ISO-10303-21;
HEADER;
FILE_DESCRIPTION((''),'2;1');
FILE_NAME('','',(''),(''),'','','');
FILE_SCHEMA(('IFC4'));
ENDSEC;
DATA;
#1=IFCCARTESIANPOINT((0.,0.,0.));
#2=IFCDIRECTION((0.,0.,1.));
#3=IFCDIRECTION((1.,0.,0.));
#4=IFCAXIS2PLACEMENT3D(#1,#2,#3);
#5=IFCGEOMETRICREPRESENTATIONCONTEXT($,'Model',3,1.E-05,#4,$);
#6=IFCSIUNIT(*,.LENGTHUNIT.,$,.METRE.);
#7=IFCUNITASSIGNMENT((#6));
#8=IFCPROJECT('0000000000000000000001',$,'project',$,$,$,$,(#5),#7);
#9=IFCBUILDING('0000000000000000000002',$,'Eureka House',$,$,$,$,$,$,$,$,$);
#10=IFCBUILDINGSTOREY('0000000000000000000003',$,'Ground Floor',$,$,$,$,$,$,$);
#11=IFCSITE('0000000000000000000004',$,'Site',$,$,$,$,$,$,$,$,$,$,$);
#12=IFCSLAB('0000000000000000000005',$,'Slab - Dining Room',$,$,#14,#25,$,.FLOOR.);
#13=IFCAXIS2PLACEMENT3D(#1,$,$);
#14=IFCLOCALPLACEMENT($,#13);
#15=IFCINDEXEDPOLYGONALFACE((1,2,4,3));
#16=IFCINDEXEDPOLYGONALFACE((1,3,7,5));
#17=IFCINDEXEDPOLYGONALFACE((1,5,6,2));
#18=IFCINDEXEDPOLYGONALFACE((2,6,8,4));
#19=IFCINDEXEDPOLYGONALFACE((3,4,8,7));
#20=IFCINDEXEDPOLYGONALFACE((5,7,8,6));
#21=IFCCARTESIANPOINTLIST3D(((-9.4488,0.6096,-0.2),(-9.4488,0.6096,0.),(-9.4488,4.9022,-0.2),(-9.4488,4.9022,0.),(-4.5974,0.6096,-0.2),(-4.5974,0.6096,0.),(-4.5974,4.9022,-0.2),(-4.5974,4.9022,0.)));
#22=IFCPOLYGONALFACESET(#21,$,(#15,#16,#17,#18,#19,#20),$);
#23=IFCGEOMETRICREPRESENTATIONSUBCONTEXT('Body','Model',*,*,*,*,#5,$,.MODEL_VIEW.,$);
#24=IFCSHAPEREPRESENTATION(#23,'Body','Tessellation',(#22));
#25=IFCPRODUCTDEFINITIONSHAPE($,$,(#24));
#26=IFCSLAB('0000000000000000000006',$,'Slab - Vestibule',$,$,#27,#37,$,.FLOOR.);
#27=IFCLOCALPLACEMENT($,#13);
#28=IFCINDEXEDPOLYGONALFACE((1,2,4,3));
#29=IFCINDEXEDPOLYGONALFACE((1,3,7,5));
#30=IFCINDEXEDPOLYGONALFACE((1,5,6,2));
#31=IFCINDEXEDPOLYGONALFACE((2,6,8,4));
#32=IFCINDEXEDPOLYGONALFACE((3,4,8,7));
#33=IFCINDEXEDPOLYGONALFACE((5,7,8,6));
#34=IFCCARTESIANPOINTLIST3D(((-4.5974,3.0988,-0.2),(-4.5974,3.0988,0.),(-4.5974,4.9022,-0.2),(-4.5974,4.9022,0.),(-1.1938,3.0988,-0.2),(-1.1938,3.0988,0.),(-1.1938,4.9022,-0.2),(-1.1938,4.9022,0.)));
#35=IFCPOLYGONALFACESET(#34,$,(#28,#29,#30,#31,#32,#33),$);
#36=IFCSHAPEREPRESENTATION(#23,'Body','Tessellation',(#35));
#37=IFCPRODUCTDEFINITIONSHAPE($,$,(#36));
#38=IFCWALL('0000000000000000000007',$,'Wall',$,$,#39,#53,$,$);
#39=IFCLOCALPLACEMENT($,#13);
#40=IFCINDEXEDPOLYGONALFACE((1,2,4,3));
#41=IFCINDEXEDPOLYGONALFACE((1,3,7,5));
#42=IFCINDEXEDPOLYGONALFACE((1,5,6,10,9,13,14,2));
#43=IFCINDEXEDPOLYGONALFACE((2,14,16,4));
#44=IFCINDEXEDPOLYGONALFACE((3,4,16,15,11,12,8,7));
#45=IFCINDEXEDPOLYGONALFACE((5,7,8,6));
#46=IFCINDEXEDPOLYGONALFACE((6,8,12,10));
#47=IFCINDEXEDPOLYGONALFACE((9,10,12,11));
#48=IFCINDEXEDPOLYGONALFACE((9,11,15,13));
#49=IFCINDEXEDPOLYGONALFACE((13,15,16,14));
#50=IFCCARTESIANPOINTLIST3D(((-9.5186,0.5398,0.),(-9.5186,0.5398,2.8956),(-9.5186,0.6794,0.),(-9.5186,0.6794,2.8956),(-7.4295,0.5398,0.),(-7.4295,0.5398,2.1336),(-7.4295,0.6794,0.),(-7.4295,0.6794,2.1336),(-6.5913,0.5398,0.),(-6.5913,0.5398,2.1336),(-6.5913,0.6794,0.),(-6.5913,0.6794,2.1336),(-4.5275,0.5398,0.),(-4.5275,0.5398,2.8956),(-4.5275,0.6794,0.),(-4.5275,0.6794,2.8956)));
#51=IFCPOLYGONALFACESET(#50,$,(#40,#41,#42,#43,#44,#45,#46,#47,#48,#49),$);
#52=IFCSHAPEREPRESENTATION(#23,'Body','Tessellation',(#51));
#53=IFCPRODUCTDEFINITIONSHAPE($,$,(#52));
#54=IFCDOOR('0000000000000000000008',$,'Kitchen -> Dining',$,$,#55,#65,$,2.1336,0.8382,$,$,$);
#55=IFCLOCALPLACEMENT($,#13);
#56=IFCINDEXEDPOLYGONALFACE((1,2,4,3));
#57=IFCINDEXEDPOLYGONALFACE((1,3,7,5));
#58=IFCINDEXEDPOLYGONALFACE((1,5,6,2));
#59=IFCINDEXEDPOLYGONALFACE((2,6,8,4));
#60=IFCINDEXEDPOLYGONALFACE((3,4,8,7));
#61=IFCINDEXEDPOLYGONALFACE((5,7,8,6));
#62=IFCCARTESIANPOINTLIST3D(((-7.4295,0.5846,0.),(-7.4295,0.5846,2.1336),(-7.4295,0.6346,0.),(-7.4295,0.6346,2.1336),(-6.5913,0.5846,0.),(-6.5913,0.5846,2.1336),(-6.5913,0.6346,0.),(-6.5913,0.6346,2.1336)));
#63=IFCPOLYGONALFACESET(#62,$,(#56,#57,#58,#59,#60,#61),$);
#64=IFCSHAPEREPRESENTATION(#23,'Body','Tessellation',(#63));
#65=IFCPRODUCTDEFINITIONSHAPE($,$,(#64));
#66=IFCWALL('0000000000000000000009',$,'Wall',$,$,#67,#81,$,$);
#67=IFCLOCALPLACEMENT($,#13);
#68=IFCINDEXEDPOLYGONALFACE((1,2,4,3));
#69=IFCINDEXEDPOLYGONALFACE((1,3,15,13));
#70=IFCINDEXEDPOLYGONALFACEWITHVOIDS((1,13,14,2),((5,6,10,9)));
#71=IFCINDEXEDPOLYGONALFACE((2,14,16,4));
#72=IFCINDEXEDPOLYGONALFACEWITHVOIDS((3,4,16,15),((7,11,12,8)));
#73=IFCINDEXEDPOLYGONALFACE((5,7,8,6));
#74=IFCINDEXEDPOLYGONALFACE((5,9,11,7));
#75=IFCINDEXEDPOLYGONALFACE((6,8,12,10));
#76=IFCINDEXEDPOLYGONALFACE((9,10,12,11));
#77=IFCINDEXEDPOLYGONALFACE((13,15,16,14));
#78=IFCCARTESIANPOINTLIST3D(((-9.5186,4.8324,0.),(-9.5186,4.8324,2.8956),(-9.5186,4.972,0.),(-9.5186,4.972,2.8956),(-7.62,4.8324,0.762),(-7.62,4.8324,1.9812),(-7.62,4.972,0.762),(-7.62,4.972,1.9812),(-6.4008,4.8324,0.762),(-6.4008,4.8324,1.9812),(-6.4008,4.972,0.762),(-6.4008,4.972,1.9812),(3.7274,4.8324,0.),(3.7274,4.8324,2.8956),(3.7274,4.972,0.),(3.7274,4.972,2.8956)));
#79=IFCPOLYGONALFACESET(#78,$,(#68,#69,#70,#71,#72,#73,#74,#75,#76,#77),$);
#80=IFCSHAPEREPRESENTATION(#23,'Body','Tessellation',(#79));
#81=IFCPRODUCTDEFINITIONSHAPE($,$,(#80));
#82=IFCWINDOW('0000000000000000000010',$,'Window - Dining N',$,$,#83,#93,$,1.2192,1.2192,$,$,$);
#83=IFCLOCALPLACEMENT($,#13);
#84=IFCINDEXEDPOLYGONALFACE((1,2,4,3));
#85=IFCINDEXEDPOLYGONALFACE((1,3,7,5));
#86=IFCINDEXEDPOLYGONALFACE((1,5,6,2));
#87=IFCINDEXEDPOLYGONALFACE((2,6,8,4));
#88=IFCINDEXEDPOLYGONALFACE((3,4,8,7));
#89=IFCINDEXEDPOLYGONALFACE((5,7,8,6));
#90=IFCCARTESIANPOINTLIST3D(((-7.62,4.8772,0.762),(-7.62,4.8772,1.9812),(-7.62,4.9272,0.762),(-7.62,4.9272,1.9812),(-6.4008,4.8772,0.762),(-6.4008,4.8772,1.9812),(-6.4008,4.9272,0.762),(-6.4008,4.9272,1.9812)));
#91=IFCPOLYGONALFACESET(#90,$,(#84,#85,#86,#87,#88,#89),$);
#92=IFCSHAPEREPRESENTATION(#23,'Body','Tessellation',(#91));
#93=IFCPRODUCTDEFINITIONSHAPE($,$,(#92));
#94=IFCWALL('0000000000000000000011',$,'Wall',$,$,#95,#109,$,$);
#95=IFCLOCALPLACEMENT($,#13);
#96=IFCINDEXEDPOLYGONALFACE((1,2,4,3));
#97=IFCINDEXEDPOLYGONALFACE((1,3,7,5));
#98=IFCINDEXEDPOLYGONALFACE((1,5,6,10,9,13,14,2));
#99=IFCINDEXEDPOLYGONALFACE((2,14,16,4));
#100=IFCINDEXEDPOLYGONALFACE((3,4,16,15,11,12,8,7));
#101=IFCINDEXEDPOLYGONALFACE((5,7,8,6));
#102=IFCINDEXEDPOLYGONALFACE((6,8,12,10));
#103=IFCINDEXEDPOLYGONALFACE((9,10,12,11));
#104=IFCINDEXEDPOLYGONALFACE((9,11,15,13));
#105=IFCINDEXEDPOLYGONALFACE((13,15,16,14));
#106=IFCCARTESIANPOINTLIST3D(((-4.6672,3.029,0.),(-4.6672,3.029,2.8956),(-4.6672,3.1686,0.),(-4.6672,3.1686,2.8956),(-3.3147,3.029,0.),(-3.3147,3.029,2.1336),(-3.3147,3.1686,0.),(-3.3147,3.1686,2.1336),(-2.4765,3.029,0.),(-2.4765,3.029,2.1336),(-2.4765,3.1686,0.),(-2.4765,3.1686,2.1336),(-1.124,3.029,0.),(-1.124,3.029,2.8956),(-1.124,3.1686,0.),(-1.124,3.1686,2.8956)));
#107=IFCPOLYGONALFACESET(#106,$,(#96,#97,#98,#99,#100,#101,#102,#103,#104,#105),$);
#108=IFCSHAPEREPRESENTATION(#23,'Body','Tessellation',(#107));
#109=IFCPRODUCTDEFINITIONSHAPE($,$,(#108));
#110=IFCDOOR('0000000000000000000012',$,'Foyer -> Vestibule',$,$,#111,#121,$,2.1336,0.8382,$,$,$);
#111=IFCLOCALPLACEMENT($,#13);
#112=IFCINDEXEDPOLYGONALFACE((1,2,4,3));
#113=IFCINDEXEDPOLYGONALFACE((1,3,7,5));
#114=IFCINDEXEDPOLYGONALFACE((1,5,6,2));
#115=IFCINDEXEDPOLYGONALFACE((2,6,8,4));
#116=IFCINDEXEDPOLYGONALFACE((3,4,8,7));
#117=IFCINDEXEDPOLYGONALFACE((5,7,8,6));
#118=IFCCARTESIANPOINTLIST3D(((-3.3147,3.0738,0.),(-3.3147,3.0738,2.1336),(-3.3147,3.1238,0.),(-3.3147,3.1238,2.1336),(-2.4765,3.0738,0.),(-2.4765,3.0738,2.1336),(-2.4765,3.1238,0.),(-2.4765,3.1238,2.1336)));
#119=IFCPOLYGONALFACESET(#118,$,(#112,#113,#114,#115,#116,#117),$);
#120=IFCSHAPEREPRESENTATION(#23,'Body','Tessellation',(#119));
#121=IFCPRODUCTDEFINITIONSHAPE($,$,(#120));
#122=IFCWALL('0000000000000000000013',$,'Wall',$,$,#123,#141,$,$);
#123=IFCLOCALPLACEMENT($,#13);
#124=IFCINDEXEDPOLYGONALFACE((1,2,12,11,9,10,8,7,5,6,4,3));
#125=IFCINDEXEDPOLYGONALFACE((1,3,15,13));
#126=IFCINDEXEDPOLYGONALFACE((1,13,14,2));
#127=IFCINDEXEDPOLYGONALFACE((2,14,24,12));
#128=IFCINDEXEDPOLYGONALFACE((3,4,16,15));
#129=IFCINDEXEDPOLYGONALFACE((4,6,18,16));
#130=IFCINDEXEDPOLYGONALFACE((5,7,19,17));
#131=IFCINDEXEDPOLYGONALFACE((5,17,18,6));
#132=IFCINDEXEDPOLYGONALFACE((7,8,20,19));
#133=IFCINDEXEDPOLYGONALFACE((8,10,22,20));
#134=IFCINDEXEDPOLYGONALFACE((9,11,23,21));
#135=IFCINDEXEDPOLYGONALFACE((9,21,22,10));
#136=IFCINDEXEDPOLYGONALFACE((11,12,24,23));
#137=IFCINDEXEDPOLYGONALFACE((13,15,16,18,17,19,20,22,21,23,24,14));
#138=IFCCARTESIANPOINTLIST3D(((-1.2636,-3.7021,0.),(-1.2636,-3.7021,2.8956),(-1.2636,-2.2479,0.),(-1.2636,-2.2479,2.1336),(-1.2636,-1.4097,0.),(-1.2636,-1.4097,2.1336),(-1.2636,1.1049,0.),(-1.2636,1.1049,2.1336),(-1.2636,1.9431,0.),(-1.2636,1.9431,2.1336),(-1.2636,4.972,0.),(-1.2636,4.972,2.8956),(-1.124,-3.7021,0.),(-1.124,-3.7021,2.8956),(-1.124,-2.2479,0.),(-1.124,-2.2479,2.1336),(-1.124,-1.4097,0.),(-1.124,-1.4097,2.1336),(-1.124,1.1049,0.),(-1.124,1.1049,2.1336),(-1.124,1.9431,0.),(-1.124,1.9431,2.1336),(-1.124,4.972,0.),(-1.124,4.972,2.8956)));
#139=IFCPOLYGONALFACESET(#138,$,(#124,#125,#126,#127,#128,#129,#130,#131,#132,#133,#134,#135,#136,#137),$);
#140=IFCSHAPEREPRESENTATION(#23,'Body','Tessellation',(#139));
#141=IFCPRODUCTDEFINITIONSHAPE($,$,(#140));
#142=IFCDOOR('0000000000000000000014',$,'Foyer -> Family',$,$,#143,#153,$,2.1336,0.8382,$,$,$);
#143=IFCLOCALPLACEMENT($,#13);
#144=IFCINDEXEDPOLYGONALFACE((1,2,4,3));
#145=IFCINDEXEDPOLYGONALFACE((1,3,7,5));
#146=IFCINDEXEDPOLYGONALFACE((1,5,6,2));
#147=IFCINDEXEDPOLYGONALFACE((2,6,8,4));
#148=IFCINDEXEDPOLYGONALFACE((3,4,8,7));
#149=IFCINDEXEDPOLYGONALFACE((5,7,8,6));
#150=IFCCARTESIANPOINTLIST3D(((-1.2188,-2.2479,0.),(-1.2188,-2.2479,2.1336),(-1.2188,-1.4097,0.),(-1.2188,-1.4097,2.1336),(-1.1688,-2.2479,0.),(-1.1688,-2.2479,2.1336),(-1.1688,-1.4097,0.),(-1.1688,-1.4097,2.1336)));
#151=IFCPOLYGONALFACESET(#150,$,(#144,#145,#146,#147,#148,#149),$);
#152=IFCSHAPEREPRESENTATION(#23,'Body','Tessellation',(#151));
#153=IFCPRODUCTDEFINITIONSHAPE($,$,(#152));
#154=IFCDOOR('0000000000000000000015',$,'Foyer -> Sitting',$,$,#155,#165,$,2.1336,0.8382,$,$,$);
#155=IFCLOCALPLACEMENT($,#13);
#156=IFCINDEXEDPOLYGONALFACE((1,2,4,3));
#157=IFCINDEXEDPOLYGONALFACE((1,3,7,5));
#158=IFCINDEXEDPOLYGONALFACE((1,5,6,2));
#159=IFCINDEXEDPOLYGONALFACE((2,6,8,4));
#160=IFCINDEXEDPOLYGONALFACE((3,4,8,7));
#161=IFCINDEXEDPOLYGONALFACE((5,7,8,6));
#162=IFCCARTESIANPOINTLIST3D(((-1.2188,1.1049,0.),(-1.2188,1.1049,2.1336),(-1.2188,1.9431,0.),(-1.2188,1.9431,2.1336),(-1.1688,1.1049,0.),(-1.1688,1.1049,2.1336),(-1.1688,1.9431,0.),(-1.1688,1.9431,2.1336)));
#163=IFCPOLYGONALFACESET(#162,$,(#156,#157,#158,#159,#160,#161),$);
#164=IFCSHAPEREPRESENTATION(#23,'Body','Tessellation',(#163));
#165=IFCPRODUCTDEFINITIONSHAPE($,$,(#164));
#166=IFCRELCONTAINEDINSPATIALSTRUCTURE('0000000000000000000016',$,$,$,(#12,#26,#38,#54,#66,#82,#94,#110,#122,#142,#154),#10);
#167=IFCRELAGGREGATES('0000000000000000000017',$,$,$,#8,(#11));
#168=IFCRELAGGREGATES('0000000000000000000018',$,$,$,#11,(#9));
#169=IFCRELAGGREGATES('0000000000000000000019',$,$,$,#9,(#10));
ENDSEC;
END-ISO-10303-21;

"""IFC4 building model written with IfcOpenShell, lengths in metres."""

from ifc_helpers import new_model, si_unit, frame, origin, origin_with_axes, origin_2d, place, context, subcontext, project, spatial, rectangle, extrude, element, fill, save


model = new_model("IFC4")

# Units and contexts
model_context = context("Model", 3, precision=1e-05, world=origin_with_axes())
body_context = subcontext(model_context, "Body", "Model", "MODEL_VIEW")
ifc_project = project(units=[si_unit("LENGTHUNIT", "METRE")], contexts=[model_context])

# Site, building, storey
site = spatial("IfcSite", under=ifc_project, Name="Site")
building = spatial("IfcBuilding", under=site, Name="Eureka House")
storey = spatial("IfcBuildingStorey", under=building, Name="Ground Floor")

# Slabs
slab_1_placement = place(None, frame((-7.0231, 2.7559, -0.2), z_axis=(0.0, 0.0, 1.0), x_axis=(1.0, 0.0, 0.0)))
element("IfcSlab", 1, at=slab_1_placement, inside=storey, Name="Slab - Dining Room", PredefinedType="FLOOR", context=body_context, shape_type="SweptSolid", body=[
    extrude(rectangle(XDim=4.8514, YDim=4.2926, at=origin_2d()), origin(), (0.0, 0.0, 1.0), 0.2),
])
slab_2_placement = place(None, frame((-2.8956, 4.0005, -0.2), z_axis=(0.0, 0.0, 1.0), x_axis=(1.0, 0.0, 0.0)))
element("IfcSlab", 2, at=slab_2_placement, inside=storey, Name="Slab - Vestibule", PredefinedType="FLOOR", context=body_context, shape_type="SweptSolid", body=[
    extrude(rectangle(XDim=3.4036, YDim=1.8034, at=origin_2d()), origin(), (0.0, 0.0, 1.0), 0.2),
])

# Wall, opening, door
wall_1_placement = place(None, frame((-7.0231, 0.6096, 0.0), z_axis=(0.0, 0.0, 1.0), x_axis=(1.0, 0.0, 0.0)))
wall_1 = element("IfcWall", 3, at=wall_1_placement, inside=storey, Name="Wall", context=body_context, shape_type="SweptSolid", body=[
    extrude(rectangle(XDim=4.9911, YDim=0.1397, at=origin_2d()), origin(), (0.0, 0.0, 1.0), 2.8956),
])
opening_1_placement = place(wall_1_placement, frame((0.0127, 0.0, 0.0), z_axis=(0.0, 0.0, 1.0), x_axis=(1.0, 0.0, 0.0)))
opening_1 = element("IfcOpeningElement", 4, at=opening_1_placement, cuts=wall_1, context=body_context, shape_type="SweptSolid", body=[
    extrude(rectangle(XDim=0.8382, YDim=0.2397, at=origin_2d()), origin(), (0.0, 0.0, 1.0), 2.1336),
])
door_1_placement = place(opening_1_placement, origin_with_axes())
door_1 = element("IfcDoor", 5, at=door_1_placement, inside=storey, Name="Kitchen -> Dining", OverallHeight=2.1336, OverallWidth=0.8382, context=body_context, shape_type="SweptSolid", body=[
    extrude(rectangle(XDim=0.8382, YDim=0.05, at=origin_2d()), origin(), (0.0, 0.0, 1.0), 2.1336),
])
fill(opening_1, door_1)

# Wall, opening, window
wall_2_placement = place(None, frame((-2.8956, 4.9022, 0.0), z_axis=(0.0, 0.0, 1.0), x_axis=(1.0, 0.0, 0.0)))
wall_2 = element("IfcWall", 6, at=wall_2_placement, inside=storey, Name="Wall", context=body_context, shape_type="SweptSolid", body=[
    extrude(rectangle(XDim=13.2461, YDim=0.1397, at=origin_2d()), origin(), (0.0, 0.0, 1.0), 2.8956),
])
opening_2_placement = place(wall_2_placement, frame((-4.1148, 0.0, 0.762), z_axis=(0.0, 0.0, 1.0), x_axis=(1.0, 0.0, 0.0)))
opening_2 = element("IfcOpeningElement", 7, at=opening_2_placement, cuts=wall_2, context=body_context, shape_type="SweptSolid", body=[
    extrude(rectangle(XDim=1.2192, YDim=0.2397, at=origin_2d()), origin(), (0.0, 0.0, 1.0), 1.2192),
])
window_1_placement = place(opening_2_placement, origin_with_axes())
window_1 = element("IfcWindow", 8, at=window_1_placement, inside=storey, Name="Window - Dining N", OverallHeight=1.2192, OverallWidth=1.2192, context=body_context, shape_type="SweptSolid", body=[
    extrude(rectangle(XDim=1.2192, YDim=0.05, at=origin_2d()), origin(), (0.0, 0.0, 1.0), 1.2192),
])
fill(opening_2, window_1)

# Wall, opening, door
wall_3_placement = place(None, frame((-2.8956, 3.0988, 0.0), z_axis=(0.0, 0.0, 1.0), x_axis=(1.0, 0.0, 0.0)))
wall_3 = element("IfcWall", 9, at=wall_3_placement, inside=storey, Name="Wall", context=body_context, shape_type="SweptSolid", body=[
    extrude(rectangle(XDim=3.5433, YDim=0.1397, at=origin_2d()), origin(), (0.0, 0.0, 1.0), 2.8956),
])
opening_3_placement = place(wall_3_placement, frame((0.0, 0.0, 0.0), z_axis=(0.0, 0.0, 1.0), x_axis=(1.0, 0.0, 0.0)))
opening_3 = element("IfcOpeningElement", 10, at=opening_3_placement, cuts=wall_3, context=body_context, shape_type="SweptSolid", body=[
    extrude(rectangle(XDim=0.8382, YDim=0.2397, at=origin_2d()), origin(), (0.0, 0.0, 1.0), 2.1336),
])
door_2_placement = place(opening_3_placement, origin_with_axes())
door_2 = element("IfcDoor", 11, at=door_2_placement, inside=storey, Name="Foyer -> Vestibule", OverallHeight=2.1336, OverallWidth=0.8382, context=body_context, shape_type="SweptSolid", body=[
    extrude(rectangle(XDim=0.8382, YDim=0.05, at=origin_2d()), origin(), (0.0, 0.0, 1.0), 2.1336),
])
fill(opening_3, door_2)

# Wall, openings, doors
wall_4_placement = place(None, frame((-1.1938, 0.635, 0.0), z_axis=(0.0, 0.0, 1.0), x_axis=(1.0, 0.0, 0.0)))
wall_4 = element("IfcWall", 12, at=wall_4_placement, inside=storey, Name="Wall", context=body_context, shape_type="SweptSolid", body=[
    extrude(rectangle(XDim=0.1397, YDim=8.6741, at=origin_2d()), origin(), (0.0, 0.0, 1.0), 2.8956),
])
opening_4_placement = place(wall_4_placement, frame((0.0, -2.4638, 0.0), z_axis=(0.0, 0.0, 1.0), x_axis=(1.0, 0.0, 0.0)))
opening_4 = element("IfcOpeningElement", 13, at=opening_4_placement, cuts=wall_4, context=body_context, shape_type="SweptSolid", body=[
    extrude(rectangle(XDim=0.2397, YDim=0.8382, at=origin_2d()), origin(), (0.0, 0.0, 1.0), 2.1336),
])
opening_5_placement = place(wall_4_placement, frame((0.0, 0.889, 0.0), z_axis=(0.0, 0.0, 1.0), x_axis=(1.0, 0.0, 0.0)))
opening_5 = element("IfcOpeningElement", 14, at=opening_5_placement, cuts=wall_4, context=body_context, shape_type="SweptSolid", body=[
    extrude(rectangle(XDim=0.2397, YDim=0.8382, at=origin_2d()), origin(), (0.0, 0.0, 1.0), 2.1336),
])
door_3_placement = place(opening_4_placement, origin_with_axes())
door_3 = element("IfcDoor", 15, at=door_3_placement, inside=storey, Name="Foyer -> Family", OverallHeight=2.1336, OverallWidth=0.8382, context=body_context, shape_type="SweptSolid", body=[
    extrude(rectangle(XDim=0.05, YDim=0.8382, at=origin_2d()), origin(), (0.0, 0.0, 1.0), 2.1336),
])
fill(opening_4, door_3)
door_4_placement = place(opening_5_placement, origin_with_axes())
door_4 = element("IfcDoor", 16, at=door_4_placement, inside=storey, Name="Foyer -> Sitting", OverallHeight=2.1336, OverallWidth=0.8382, context=body_context, shape_type="SweptSolid", body=[
    extrude(rectangle(XDim=0.05, YDim=0.8382, at=origin_2d()), origin(), (0.0, 0.0, 1.0), 2.1336),
])
fill(opening_5, door_4)

save(model, "model.ifc")
